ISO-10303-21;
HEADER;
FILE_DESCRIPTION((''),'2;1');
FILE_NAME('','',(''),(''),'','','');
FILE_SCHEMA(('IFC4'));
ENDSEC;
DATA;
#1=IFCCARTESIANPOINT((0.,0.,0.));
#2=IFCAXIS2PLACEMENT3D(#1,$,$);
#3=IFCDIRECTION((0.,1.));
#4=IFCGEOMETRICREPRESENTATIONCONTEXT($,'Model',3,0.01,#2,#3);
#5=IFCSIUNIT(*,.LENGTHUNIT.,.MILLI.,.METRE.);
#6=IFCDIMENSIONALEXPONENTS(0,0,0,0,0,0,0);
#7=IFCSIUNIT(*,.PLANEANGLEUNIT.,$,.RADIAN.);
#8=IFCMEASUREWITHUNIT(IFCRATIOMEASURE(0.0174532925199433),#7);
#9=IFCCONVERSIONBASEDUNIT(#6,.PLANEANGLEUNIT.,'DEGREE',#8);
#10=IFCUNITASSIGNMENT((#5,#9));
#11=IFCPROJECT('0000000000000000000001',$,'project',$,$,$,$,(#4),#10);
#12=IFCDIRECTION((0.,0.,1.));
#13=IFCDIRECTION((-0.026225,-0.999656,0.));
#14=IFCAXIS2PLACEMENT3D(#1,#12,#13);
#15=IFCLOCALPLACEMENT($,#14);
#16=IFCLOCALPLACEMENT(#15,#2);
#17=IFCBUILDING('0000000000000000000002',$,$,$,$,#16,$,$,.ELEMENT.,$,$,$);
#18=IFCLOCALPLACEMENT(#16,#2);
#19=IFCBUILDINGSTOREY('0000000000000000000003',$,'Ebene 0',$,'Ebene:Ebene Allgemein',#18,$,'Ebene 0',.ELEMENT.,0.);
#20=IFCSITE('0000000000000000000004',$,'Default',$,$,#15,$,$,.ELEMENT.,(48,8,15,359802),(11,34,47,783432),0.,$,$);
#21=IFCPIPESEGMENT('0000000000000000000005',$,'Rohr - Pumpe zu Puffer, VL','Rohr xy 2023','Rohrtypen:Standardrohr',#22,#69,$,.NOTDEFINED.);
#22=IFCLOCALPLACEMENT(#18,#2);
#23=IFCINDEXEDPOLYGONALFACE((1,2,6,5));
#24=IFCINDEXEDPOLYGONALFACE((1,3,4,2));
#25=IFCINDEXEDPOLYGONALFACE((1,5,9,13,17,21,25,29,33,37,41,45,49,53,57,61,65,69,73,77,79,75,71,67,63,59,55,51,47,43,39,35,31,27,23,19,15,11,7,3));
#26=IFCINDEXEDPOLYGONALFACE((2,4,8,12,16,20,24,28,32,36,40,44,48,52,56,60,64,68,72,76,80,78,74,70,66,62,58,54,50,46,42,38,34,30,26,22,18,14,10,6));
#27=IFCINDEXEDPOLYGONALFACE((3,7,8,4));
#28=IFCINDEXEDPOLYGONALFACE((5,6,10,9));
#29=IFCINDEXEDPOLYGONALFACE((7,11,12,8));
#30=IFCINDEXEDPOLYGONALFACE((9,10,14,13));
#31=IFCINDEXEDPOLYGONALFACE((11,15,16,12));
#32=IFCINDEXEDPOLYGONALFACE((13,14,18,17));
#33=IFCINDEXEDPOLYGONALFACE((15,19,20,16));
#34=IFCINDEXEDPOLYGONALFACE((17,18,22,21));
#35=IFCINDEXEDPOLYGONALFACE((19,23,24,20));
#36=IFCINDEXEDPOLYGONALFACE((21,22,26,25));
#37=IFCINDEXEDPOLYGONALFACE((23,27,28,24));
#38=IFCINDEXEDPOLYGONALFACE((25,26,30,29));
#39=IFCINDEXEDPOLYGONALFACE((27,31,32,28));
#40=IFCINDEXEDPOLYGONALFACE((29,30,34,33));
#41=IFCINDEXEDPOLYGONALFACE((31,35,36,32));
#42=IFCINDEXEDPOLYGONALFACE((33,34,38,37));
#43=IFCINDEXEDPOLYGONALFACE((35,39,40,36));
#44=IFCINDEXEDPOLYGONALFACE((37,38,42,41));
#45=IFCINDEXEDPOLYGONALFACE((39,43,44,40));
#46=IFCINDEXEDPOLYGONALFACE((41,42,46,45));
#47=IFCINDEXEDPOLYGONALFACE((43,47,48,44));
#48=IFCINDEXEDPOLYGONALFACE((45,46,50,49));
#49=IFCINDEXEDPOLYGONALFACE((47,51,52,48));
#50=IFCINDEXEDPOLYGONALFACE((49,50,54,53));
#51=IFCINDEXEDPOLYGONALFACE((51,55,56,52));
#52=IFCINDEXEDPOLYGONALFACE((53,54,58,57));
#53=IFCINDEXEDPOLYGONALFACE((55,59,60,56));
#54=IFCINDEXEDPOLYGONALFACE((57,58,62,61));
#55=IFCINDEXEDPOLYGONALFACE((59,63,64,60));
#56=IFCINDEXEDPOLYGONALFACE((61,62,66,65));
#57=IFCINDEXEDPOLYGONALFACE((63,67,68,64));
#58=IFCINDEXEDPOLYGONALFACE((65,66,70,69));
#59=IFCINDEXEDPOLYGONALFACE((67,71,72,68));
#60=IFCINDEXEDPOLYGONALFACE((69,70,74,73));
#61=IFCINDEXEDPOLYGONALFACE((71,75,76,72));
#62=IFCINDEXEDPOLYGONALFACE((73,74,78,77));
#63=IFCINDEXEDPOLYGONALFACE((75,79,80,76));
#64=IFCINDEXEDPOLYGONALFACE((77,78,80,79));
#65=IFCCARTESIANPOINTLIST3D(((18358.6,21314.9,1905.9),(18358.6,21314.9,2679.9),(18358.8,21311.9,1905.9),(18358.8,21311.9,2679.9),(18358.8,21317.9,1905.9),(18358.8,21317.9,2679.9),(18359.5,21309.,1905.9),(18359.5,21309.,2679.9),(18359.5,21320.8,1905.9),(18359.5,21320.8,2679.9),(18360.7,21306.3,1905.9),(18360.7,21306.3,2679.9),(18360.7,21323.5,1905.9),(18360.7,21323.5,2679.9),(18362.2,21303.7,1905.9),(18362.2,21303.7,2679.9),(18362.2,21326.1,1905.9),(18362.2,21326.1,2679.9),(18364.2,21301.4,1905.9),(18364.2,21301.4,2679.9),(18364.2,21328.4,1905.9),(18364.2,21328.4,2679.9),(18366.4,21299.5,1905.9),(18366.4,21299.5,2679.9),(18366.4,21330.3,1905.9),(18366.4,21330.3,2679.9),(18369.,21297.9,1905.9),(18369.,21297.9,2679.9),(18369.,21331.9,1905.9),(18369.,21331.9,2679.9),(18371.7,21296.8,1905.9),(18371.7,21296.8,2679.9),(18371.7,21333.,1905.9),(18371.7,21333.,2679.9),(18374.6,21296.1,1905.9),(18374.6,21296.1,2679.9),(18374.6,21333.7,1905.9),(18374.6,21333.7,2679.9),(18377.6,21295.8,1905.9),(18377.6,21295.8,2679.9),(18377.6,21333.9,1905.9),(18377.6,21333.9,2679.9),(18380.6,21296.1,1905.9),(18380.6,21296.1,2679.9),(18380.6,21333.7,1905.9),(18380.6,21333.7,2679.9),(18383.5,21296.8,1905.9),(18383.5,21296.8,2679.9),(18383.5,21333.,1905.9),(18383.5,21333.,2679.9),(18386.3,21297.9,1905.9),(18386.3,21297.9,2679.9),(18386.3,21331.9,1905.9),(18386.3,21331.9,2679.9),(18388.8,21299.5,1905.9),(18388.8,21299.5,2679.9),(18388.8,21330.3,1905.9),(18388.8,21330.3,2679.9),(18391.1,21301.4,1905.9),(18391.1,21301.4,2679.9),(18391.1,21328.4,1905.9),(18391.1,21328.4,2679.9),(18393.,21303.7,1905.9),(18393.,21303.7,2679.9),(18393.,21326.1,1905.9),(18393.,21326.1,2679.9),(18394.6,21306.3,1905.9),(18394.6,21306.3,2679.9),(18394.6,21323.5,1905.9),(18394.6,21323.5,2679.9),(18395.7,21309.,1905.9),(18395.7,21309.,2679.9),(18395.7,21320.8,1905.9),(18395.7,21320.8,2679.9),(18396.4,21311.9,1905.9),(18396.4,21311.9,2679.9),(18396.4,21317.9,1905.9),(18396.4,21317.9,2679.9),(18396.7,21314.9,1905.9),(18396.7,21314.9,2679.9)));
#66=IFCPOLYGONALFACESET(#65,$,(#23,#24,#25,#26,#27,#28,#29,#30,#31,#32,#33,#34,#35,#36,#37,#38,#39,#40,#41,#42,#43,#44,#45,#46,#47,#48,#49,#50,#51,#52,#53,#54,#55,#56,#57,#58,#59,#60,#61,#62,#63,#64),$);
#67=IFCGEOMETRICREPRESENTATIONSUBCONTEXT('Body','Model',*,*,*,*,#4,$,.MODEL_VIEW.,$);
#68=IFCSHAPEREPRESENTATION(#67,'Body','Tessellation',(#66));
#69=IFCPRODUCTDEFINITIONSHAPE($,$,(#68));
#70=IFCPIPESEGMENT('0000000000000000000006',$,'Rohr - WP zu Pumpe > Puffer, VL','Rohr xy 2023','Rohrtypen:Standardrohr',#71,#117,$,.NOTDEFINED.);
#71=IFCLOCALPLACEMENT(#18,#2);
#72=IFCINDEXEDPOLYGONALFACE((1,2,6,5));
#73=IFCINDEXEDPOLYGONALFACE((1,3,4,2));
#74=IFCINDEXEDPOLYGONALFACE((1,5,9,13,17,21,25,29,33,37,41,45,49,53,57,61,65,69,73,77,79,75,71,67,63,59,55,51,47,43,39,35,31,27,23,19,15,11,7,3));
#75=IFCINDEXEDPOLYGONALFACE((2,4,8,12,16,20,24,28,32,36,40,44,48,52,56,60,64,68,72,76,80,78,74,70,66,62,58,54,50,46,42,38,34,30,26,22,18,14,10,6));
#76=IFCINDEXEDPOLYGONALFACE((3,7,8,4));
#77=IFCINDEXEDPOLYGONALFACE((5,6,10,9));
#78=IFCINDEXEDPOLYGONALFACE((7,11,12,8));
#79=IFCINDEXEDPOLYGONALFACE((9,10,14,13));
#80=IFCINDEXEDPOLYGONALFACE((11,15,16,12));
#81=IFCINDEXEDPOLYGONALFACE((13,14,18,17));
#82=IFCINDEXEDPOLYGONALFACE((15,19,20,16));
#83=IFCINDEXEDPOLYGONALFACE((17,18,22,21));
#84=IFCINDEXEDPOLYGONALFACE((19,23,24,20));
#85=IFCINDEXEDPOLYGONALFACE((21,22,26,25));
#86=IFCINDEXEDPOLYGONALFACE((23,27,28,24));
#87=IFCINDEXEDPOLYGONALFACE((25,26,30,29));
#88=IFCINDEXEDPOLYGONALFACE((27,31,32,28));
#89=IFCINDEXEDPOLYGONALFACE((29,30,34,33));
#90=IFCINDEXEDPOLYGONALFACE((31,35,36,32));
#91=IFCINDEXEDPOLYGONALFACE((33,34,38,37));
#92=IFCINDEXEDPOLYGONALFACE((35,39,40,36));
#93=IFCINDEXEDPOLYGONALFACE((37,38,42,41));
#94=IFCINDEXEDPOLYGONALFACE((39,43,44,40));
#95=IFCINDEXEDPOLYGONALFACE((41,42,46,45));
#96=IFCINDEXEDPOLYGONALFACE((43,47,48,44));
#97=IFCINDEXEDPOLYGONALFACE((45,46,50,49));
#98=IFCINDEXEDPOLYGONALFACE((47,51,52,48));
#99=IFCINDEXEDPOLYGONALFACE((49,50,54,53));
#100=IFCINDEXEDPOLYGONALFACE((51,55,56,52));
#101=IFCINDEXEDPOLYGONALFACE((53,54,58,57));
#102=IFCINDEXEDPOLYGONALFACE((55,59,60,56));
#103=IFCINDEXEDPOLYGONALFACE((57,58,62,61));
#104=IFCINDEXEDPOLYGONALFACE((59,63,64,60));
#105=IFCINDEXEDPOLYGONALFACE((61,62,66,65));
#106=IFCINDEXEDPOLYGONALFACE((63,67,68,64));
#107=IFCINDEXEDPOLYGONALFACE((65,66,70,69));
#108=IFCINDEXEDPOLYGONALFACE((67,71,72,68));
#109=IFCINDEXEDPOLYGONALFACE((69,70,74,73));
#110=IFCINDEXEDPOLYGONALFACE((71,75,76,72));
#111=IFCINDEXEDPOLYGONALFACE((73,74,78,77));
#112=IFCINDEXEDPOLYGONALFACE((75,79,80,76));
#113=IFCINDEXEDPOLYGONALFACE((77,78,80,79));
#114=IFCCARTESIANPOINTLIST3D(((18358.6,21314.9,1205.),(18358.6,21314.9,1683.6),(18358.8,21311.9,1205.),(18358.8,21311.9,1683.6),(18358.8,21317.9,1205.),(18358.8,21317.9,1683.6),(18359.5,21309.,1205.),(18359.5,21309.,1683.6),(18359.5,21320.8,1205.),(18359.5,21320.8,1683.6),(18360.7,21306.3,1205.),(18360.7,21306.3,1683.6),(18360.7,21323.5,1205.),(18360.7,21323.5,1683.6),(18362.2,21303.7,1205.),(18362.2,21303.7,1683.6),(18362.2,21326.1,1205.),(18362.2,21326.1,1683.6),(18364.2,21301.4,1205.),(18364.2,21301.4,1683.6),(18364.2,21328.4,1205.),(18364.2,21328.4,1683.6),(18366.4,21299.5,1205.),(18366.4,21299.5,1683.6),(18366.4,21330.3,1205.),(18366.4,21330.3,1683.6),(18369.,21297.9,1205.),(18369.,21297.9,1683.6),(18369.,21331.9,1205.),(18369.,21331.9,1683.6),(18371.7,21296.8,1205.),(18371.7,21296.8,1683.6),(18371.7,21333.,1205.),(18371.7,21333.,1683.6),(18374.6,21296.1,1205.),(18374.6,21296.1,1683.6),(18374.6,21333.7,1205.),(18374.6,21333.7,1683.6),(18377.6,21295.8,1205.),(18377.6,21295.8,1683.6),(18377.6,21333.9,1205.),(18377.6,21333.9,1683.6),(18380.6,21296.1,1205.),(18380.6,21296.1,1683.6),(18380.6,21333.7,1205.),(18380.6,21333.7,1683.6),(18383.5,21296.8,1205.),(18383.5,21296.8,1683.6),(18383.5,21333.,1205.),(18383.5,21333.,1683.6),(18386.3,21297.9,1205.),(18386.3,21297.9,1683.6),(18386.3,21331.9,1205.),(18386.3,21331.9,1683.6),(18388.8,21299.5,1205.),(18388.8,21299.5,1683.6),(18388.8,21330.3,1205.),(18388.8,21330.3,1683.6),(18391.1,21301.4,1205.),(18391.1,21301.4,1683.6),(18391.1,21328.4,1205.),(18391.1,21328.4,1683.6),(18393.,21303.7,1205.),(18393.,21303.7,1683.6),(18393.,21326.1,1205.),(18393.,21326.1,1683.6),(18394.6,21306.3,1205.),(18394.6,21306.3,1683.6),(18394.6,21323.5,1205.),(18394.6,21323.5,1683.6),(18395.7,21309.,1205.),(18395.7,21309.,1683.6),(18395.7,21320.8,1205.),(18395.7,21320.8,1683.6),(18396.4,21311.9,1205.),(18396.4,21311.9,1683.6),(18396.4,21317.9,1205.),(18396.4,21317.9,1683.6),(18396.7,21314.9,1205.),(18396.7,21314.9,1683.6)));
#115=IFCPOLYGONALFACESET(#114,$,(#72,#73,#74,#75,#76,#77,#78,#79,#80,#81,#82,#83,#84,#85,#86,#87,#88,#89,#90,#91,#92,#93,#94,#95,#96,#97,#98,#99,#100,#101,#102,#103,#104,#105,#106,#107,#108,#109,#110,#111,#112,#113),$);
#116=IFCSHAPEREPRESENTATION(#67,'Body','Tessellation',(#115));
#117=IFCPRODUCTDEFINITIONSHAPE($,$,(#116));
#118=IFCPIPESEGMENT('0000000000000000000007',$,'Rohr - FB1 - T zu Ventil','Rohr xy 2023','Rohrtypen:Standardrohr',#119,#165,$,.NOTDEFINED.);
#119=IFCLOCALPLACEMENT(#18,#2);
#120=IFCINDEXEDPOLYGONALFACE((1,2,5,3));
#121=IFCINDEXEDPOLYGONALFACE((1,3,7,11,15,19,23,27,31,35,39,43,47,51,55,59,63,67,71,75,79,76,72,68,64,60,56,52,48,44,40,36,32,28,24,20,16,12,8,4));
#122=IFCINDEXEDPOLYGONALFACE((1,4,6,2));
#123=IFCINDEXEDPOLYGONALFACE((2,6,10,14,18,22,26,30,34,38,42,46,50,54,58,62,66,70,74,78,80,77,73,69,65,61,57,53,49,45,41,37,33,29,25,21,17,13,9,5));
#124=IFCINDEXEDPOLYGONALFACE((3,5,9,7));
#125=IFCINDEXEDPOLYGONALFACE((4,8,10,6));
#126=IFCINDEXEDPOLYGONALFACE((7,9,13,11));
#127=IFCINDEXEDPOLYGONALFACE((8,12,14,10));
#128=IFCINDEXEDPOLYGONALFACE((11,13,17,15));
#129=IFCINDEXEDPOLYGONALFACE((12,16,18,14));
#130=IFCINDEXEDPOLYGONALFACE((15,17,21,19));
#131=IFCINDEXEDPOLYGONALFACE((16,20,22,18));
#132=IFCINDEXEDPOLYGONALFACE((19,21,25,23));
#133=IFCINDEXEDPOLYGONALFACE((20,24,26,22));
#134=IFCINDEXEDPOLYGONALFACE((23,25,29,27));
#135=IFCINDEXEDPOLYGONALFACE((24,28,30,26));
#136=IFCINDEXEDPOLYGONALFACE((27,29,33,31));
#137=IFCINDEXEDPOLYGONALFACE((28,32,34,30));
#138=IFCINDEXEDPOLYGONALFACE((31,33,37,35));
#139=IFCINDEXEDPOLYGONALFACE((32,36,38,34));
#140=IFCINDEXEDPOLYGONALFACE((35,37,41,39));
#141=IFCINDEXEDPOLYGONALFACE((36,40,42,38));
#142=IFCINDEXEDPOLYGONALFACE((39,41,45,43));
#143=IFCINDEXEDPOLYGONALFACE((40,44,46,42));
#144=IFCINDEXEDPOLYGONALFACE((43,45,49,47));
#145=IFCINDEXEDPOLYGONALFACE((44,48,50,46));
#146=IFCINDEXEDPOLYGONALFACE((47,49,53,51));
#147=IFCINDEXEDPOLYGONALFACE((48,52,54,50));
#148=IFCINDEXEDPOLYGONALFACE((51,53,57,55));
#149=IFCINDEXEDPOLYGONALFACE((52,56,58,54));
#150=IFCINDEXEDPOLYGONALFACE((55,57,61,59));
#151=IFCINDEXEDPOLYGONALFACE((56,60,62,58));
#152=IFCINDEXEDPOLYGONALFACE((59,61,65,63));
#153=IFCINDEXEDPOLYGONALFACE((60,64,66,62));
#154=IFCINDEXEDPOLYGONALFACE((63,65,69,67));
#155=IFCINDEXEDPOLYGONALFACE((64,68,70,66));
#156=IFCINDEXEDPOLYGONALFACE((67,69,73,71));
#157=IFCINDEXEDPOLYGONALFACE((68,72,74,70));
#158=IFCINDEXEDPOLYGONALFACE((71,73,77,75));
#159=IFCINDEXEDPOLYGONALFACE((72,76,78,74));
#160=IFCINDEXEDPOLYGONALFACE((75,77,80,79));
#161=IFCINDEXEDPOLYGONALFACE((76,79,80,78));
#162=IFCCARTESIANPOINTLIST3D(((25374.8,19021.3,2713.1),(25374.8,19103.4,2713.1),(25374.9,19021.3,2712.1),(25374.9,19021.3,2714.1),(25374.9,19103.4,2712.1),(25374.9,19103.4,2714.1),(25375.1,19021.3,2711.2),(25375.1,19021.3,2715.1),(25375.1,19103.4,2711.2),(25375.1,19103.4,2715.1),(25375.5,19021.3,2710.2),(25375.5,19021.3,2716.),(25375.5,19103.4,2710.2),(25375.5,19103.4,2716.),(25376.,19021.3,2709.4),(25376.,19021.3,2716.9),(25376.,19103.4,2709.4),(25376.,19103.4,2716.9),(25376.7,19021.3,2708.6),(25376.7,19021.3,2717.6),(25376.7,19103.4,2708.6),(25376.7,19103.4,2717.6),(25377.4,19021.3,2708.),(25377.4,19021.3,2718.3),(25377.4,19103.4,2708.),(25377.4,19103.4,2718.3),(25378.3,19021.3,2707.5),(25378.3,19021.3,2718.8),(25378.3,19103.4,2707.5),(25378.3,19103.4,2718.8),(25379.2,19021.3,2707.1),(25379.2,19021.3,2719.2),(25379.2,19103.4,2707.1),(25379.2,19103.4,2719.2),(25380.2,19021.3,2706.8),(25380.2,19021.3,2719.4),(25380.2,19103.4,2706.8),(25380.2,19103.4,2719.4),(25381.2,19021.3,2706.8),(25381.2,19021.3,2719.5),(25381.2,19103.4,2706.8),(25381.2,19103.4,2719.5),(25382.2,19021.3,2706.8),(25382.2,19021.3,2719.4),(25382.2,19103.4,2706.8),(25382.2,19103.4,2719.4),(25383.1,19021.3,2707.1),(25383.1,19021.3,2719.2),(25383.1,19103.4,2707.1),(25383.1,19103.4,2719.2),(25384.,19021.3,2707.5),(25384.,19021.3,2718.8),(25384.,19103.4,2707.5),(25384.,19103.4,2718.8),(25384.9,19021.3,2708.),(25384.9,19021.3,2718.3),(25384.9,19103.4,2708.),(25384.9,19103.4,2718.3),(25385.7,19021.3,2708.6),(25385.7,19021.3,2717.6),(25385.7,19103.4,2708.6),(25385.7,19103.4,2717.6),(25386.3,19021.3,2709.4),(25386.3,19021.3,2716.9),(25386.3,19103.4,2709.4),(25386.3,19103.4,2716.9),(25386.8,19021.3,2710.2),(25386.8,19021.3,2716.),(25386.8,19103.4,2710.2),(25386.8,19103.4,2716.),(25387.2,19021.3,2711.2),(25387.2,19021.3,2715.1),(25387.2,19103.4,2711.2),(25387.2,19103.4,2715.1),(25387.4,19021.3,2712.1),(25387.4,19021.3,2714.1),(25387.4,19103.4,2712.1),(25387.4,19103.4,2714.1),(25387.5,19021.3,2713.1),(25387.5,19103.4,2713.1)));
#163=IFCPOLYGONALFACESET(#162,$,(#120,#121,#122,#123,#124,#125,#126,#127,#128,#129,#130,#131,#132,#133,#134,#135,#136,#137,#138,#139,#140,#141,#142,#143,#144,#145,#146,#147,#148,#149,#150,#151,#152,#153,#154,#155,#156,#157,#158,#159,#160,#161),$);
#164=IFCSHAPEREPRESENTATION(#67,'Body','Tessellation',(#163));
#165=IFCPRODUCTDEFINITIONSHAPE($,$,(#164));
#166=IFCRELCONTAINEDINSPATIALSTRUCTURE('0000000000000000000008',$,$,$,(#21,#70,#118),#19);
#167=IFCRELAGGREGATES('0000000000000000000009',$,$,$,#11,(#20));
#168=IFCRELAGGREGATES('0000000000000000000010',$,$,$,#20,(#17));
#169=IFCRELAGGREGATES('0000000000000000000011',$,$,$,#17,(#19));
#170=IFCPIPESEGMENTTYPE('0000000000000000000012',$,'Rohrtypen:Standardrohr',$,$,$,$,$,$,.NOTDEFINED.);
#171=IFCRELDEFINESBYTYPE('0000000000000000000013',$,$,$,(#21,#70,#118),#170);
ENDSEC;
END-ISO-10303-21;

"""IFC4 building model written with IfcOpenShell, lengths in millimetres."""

from ifc_helpers import new_model, entity, si_unit, converted_unit, direction, frame, origin, place, context, subcontext, project, spatial, indexed_curve, outline, extrude, type_object, element, save


model = new_model("IFC4")

# Units and contexts
model_context = context("Model", 3, precision=0.01, world=origin(), true_north=direction((0.0, 1.0)))
body_context = subcontext(model_context, "Body", "Model", "MODEL_VIEW")
ifc_project = project(units=[si_unit("LENGTHUNIT", "METRE", prefix="MILLI"), converted_unit("PLANEANGLEUNIT", "DEGREE", entity("IfcRatioMeasure", 0.0174532925199433), si_unit("PLANEANGLEUNIT", "RADIAN"), dimensions=[0, 0, 0, 0, 0, 0, 0])], contexts=[model_context])

# Site, building, storey
site_placement = place(None, frame((0.0, 0.0, 0.0), z_axis=(0.0, 0.0, 1.0), x_axis=(-0.026225, -0.999656, 0.0)))
site = spatial("IfcSite", under=ifc_project, at=site_placement, Name="Default", CompositionType="ELEMENT", RefLatitude=(48, 8, 15, 359802), RefLongitude=(11, 34, 47, 783432), RefElevation=0.0)
building_placement = place(site_placement, origin())
building = spatial("IfcBuilding", under=site, at=building_placement, CompositionType="ELEMENT")
storey_placement = place(building_placement, origin())
storey = spatial("IfcBuildingStorey", under=building, at=storey_placement, Name="Ebene 0", ObjectType="Ebene:Ebene Allgemein", LongName="Ebene 0", CompositionType="ELEMENT", Elevation=0.0)

# Pipe segments
pipe_segment_type = type_object("IfcPipeSegmentType", Name="Rohrtypen:Standardrohr", PredefinedType="NOTDEFINED")
pipe_segment_1_placement = place(storey_placement, origin())
element("IfcPipeSegment", 1, at=pipe_segment_1_placement, inside=storey, type_object=pipe_segment_type, Name="Rohr - Pumpe zu Puffer, VL", Description="Rohr xy 2023", ObjectType="Rohrtypen:Standardrohr", PredefinedType="NOTDEFINED", context=body_context, shape_type="SweptSolid", body=[
    extrude(outline(indexed_curve([(19.1, 0.0), (18.8, 3.0), (18.1, 5.9), (17.0, 8.6), (15.4, 11.2), (13.5, 13.5), (11.2, 15.4), (8.6, 17.0), (5.9, 18.1), (3.0, 18.8), (0.0, 19.1), (-3.0, 18.8), (-5.9, 18.1), (-8.6, 17.0), (-11.2, 15.4), (-13.5, 13.5), (-15.4, 11.2), (-17.0, 8.6), (-18.1, 5.9), (-18.8, 3.0), (-19.1, 0.0), (-18.8, -3.0), (-18.1, -5.9), (-17.0, -8.6), (-15.4, -11.2), (-13.5, -13.5), (-11.2, -15.4), (-8.6, -17.0), (-5.9, -18.1), (-3.0, -18.8), (0.0, -19.1), (3.0, -18.8), (5.9, -18.1), (8.6, -17.0), (11.2, -15.4), (13.5, -13.5), (15.4, -11.2), (17.0, -8.6), (18.1, -5.9), (18.8, -3.0), (19.1, 0.0)], self_intersect=False)), frame((18377.6, 21314.9, 1905.9), z_axis=(0.0, 0.0, 1.0), x_axis=(-1.0, 0.0, 0.0)), (0.0, 0.0, 1.0), 774.0),
])
pipe_segment_2_placement = place(storey_placement, origin())
element("IfcPipeSegment", 2, at=pipe_segment_2_placement, inside=storey, type_object=pipe_segment_type, Name="Rohr - WP zu Pumpe > Puffer, VL", Description="Rohr xy 2023", ObjectType="Rohrtypen:Standardrohr", PredefinedType="NOTDEFINED", context=body_context, shape_type="SweptSolid", body=[
    extrude(outline(indexed_curve([(19.1, 0.0), (18.8, 3.0), (18.1, 5.9), (17.0, 8.6), (15.4, 11.2), (13.5, 13.5), (11.2, 15.4), (8.6, 17.0), (5.9, 18.1), (3.0, 18.8), (0.0, 19.1), (-3.0, 18.8), (-5.9, 18.1), (-8.6, 17.0), (-11.2, 15.4), (-13.5, 13.5), (-15.4, 11.2), (-17.0, 8.6), (-18.1, 5.9), (-18.8, 3.0), (-19.1, 0.0), (-18.8, -3.0), (-18.1, -5.9), (-17.0, -8.6), (-15.4, -11.2), (-13.5, -13.5), (-11.2, -15.4), (-8.6, -17.0), (-5.9, -18.1), (-3.0, -18.8), (0.0, -19.1), (3.0, -18.8), (5.9, -18.1), (8.6, -17.0), (11.2, -15.4), (13.5, -13.5), (15.4, -11.2), (17.0, -8.6), (18.1, -5.9), (18.8, -3.0), (19.1, 0.0)], self_intersect=False)), frame((18377.6, 21314.9, 1205.0), z_axis=(0.0, 0.0, 1.0), x_axis=(-1.0, 0.0, 0.0)), (0.0, 0.0, 1.0), 478.6),
])
pipe_segment_3_placement = place(storey_placement, origin())
element("IfcPipeSegment", 3, at=pipe_segment_3_placement, inside=storey, type_object=pipe_segment_type, Name="Rohr - FB1 - T zu Ventil", Description="Rohr xy 2023", ObjectType="Rohrtypen:Standardrohr", PredefinedType="NOTDEFINED", context=body_context, shape_type="SweptSolid", body=[
    extrude(outline(indexed_curve([(6.3, 0.0), (6.3, 1.0), (6.0, 2.0), (5.7, 2.9), (5.1, 3.7), (4.5, 4.5), (3.7, 5.1), (2.9, 5.7), (2.0, 6.0), (1.0, 6.3), (0.0, 6.4), (-1.0, 6.3), (-2.0, 6.0), (-2.9, 5.7), (-3.7, 5.1), (-4.5, 4.5), (-5.1, 3.7), (-5.7, 2.9), (-6.0, 2.0), (-6.3, 1.0), (-6.3, 0.0), (-6.3, -1.0), (-6.0, -2.0), (-5.7, -2.9), (-5.1, -3.7), (-4.5, -4.5), (-3.7, -5.1), (-2.9, -5.7), (-2.0, -6.0), (-1.0, -6.3), (0.0, -6.4), (1.0, -6.3), (2.0, -6.0), (2.9, -5.7), (3.7, -5.1), (4.5, -4.5), (5.1, -3.7), (5.7, -2.9), (6.0, -2.0), (6.3, -1.0), (6.3, 0.0)], self_intersect=False)), frame((25381.2, 19021.3, 2713.1), z_axis=(0.0, 1.0, 0.0), x_axis=(-1.0, 0.0, 0.0)), (0.0, 0.0, 1.0), 82.2),
])

save(model, "model.ifc")
